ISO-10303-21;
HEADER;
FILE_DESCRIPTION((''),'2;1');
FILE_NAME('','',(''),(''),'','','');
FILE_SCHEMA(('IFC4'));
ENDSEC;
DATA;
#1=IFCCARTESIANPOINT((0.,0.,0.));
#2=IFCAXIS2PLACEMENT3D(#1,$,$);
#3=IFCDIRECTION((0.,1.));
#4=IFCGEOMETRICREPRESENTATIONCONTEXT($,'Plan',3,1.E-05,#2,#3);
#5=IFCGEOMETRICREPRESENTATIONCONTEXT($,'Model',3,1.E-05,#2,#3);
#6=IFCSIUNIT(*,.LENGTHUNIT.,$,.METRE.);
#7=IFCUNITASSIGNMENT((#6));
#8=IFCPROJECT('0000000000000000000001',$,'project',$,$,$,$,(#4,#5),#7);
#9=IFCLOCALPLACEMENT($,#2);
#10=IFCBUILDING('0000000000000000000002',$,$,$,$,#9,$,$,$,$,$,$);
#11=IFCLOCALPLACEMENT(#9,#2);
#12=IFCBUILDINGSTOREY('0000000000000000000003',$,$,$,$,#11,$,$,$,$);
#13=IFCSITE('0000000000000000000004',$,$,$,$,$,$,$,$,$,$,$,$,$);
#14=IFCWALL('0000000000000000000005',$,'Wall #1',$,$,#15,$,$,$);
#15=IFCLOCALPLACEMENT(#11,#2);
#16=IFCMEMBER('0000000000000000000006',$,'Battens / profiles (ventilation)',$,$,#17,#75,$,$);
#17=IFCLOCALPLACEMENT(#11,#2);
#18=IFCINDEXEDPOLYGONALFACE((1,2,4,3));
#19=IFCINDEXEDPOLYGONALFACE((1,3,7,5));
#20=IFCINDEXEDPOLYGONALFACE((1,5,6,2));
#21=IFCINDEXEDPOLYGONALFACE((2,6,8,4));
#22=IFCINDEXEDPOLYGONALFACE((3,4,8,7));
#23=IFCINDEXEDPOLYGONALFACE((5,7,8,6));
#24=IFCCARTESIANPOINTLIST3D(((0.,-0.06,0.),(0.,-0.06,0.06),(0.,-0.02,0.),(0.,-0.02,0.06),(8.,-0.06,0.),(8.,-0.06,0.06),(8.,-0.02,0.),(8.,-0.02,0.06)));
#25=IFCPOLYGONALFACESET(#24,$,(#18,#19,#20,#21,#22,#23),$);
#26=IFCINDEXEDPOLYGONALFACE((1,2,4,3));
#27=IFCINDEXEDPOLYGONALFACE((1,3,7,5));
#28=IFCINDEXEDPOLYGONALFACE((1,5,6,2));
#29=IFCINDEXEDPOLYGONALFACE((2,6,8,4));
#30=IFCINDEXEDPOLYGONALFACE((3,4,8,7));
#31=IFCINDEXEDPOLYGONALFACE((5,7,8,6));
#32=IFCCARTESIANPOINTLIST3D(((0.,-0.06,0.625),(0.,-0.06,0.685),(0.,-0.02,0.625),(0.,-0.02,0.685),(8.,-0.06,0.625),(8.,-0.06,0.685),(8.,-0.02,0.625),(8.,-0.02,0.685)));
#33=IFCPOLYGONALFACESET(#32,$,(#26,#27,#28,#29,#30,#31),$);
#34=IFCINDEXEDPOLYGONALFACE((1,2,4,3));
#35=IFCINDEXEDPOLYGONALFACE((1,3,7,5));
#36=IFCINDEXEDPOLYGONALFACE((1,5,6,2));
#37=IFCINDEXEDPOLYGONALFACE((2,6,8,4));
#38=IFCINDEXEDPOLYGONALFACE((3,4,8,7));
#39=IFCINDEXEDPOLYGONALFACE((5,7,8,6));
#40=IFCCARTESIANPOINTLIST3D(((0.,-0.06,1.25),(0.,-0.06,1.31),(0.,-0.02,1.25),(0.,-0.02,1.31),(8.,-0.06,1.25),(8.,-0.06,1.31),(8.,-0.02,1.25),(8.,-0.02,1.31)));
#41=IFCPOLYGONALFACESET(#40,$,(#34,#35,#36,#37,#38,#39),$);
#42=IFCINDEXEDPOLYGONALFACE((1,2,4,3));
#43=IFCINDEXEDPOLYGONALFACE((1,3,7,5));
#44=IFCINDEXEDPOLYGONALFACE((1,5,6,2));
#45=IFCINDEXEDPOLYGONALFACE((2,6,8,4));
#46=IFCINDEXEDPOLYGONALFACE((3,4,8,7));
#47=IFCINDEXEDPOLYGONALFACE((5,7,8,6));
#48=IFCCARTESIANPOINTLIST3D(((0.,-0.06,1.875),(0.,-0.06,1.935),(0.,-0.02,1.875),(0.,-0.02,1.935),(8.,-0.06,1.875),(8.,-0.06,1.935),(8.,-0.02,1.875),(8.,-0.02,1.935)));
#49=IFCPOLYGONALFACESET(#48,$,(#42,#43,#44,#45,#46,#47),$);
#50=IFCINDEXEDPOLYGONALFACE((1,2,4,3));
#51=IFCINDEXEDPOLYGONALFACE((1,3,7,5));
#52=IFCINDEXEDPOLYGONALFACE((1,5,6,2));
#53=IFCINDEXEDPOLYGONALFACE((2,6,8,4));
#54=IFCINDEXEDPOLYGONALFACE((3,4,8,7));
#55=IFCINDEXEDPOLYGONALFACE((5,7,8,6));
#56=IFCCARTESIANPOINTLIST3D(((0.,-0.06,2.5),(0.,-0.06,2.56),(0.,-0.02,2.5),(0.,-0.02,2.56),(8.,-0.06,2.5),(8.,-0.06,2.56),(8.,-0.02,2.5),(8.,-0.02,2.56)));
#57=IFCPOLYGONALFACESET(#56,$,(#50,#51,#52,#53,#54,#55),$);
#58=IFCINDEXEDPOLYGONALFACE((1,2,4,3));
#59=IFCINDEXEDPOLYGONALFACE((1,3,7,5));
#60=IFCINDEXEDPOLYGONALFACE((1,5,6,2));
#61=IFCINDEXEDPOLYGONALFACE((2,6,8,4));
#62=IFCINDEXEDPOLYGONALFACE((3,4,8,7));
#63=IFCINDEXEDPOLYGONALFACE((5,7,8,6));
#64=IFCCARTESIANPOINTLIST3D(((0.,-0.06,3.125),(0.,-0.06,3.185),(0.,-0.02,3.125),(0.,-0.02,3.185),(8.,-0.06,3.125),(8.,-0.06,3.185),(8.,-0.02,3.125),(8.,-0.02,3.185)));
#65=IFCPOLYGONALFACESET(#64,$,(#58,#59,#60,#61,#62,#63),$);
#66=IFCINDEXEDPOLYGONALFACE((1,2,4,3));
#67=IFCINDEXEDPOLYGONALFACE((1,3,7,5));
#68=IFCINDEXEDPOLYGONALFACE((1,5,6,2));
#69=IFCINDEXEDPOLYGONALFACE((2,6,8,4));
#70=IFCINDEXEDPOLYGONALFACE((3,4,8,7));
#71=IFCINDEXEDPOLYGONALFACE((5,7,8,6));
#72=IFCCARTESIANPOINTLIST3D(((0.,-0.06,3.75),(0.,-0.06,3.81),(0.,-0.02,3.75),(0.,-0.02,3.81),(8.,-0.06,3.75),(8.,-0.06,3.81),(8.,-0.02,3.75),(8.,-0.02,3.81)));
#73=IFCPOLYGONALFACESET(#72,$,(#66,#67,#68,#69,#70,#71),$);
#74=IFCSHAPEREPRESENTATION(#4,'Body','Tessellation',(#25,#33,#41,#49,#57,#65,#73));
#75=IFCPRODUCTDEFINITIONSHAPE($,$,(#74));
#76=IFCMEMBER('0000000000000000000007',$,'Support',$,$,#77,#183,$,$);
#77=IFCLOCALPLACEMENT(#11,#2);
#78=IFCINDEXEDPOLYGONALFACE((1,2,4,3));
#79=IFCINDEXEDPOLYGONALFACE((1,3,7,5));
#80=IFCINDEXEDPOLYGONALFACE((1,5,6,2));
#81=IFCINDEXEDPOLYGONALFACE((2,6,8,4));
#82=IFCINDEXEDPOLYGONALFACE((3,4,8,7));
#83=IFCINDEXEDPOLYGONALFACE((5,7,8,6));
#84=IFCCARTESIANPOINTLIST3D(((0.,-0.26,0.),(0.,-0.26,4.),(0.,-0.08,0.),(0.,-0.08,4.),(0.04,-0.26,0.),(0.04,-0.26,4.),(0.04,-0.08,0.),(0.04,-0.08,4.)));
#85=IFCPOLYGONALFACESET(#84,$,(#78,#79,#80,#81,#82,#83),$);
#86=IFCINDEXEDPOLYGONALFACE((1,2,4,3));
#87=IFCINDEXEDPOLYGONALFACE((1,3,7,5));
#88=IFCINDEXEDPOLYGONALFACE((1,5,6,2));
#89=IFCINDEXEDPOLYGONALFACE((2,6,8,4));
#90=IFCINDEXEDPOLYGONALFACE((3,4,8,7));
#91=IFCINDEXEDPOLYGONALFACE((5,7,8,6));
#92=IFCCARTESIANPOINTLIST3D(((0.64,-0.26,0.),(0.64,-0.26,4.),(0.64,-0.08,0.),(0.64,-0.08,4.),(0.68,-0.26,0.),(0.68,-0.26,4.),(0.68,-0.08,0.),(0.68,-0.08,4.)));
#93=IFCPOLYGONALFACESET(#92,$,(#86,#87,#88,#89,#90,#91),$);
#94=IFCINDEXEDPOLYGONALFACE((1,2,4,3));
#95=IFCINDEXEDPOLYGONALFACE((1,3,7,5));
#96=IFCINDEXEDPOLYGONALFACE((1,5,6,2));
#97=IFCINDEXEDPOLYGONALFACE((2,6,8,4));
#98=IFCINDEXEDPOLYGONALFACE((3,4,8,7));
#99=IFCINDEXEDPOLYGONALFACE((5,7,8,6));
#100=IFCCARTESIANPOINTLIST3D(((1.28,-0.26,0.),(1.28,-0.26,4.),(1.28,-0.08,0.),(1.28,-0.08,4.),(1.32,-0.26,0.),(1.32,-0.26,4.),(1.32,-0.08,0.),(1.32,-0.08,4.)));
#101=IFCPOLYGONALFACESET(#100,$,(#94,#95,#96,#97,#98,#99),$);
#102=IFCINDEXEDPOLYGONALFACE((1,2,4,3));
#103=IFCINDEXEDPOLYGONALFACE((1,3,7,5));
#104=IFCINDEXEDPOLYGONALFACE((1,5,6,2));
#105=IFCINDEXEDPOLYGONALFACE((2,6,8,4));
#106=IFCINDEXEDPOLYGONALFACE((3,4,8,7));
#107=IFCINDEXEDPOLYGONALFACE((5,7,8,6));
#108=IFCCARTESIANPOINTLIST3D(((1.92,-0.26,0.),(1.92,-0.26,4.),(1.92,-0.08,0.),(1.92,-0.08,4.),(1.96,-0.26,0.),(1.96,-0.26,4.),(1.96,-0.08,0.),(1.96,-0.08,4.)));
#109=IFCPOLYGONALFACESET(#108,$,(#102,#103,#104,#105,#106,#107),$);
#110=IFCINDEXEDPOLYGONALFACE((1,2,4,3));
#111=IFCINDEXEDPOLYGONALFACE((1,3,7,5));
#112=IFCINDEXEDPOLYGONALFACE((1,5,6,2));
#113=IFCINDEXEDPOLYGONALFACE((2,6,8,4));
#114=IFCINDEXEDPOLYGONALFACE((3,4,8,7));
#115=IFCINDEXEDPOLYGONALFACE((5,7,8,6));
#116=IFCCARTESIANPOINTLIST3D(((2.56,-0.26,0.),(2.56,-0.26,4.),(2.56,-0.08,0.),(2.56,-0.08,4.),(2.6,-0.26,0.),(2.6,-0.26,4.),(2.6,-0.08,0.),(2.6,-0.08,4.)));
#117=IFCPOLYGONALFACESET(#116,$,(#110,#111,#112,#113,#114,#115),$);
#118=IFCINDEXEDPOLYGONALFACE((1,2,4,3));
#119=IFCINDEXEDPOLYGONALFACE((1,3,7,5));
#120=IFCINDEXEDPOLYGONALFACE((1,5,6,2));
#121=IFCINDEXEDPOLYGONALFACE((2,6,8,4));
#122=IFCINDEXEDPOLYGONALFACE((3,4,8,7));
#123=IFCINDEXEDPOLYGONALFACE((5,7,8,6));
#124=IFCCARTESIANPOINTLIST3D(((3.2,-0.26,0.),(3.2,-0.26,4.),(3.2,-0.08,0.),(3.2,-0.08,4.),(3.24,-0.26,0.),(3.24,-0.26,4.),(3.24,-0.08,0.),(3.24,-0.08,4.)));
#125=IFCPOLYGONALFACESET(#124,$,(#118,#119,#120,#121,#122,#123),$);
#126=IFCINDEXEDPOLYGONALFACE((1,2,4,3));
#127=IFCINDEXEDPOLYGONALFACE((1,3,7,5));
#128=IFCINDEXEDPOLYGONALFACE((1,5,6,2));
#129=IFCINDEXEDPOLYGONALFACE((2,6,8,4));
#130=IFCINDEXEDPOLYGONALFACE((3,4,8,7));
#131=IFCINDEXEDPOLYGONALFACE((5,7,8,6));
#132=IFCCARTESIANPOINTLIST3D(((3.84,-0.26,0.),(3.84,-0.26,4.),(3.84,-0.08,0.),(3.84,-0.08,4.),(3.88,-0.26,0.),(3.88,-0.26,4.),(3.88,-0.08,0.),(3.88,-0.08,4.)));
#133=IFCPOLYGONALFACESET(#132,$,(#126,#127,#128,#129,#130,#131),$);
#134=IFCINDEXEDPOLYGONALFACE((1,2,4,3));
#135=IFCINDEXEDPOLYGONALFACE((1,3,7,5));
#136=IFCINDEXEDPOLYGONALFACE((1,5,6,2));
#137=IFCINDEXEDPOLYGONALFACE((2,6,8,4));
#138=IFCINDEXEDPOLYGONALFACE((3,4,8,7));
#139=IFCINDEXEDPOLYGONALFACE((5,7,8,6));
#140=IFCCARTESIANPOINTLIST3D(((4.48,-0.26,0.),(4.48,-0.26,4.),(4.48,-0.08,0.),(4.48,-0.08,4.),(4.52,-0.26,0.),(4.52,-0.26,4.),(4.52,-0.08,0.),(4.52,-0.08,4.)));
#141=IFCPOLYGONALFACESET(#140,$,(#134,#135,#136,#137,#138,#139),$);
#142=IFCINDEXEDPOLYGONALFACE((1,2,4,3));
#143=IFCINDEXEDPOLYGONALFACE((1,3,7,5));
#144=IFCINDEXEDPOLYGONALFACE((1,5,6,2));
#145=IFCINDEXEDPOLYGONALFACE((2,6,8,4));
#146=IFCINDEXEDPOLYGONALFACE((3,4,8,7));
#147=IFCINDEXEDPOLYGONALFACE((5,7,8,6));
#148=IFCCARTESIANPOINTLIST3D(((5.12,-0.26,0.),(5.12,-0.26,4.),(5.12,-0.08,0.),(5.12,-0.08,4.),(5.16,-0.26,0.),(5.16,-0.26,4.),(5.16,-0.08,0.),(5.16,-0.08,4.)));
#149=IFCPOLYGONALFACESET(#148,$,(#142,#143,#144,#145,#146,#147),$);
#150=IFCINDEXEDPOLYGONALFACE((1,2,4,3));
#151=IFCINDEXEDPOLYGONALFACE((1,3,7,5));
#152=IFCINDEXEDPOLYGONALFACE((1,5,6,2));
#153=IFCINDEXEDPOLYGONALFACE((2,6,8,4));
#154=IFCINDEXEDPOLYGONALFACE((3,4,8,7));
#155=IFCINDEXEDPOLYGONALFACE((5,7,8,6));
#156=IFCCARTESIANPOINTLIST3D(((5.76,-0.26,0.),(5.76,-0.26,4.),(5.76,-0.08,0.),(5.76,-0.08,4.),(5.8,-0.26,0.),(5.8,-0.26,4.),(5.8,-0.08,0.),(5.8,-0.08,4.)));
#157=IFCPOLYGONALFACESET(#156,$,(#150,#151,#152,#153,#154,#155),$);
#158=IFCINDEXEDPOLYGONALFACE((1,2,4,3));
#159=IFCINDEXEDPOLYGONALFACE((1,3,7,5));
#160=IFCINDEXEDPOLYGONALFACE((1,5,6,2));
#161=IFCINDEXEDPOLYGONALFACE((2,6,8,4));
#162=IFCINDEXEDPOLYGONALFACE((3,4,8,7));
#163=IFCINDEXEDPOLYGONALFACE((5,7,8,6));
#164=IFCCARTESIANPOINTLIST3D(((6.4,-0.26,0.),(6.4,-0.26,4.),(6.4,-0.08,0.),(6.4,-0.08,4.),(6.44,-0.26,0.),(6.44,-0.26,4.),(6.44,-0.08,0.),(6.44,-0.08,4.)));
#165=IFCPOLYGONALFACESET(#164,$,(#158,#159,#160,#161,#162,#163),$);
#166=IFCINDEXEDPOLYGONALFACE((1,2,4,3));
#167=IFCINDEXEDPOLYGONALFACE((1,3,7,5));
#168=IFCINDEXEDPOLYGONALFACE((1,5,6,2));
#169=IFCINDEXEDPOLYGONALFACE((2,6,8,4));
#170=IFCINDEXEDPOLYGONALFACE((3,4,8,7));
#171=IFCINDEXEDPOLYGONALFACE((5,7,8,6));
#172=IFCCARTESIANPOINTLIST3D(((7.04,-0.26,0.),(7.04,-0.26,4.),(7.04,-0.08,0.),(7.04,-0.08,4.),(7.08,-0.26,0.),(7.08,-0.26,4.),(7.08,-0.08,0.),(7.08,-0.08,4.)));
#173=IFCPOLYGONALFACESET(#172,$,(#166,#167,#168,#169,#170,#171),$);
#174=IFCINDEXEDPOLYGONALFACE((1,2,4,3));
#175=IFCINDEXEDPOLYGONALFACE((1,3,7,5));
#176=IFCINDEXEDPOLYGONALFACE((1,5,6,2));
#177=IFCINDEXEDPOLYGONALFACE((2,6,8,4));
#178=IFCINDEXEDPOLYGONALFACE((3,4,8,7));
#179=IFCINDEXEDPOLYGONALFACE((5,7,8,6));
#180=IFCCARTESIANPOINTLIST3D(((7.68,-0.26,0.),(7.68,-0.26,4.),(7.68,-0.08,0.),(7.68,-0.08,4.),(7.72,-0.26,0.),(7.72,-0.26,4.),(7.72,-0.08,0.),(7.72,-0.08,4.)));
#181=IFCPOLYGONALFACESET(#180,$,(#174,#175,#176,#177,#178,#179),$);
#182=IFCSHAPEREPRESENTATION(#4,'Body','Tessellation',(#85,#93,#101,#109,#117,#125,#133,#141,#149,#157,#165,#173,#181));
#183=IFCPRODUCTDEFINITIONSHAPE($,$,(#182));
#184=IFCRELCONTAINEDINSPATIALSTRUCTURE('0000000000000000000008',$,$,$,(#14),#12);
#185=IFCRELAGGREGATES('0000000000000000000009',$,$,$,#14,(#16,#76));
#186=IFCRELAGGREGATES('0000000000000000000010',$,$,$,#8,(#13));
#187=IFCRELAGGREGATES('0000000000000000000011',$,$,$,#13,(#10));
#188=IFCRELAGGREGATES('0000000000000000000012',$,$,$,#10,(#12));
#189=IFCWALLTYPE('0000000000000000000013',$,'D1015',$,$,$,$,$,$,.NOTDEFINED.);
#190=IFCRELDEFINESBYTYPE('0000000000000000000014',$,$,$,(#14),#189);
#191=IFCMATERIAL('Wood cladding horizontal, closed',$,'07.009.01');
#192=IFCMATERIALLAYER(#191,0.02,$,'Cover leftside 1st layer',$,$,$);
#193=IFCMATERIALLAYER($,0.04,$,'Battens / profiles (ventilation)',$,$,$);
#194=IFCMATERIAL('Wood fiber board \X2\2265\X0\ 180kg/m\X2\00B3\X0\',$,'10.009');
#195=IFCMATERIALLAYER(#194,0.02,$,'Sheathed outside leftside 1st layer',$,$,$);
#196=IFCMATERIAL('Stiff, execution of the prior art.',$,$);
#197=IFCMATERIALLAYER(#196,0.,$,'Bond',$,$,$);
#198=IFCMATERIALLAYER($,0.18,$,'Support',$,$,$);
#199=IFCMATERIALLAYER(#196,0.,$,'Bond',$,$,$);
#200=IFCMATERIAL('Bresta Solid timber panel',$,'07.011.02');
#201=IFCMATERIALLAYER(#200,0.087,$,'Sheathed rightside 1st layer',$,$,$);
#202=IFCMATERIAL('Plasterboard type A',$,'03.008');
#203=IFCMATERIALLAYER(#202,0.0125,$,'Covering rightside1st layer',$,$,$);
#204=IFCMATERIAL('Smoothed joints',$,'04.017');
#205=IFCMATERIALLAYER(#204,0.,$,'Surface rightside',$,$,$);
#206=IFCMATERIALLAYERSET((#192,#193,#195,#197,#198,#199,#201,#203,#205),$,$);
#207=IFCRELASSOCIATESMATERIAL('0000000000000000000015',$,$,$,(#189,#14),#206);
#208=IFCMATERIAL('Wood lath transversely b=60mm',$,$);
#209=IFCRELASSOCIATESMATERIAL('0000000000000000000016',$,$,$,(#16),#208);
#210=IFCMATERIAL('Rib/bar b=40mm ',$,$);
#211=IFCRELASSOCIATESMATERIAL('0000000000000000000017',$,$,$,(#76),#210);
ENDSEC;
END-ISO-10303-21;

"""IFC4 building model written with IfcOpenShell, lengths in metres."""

from ifc_helpers import new_model, si_unit, direction, frame, frame_2d, origin, place, context, project, spatial, rectangle, extrude, material, layer, layer_set, type_object, element, aggregate, save


model = new_model("IFC4")

# Units and contexts
plan_context = context("Plan", 3, precision=1e-05, world=origin(), true_north=direction((0.0, 1.0)))
model_context = context("Model", 3, precision=1e-05, world=origin(), true_north=direction((0.0, 1.0)))
ifc_project = project(units=[si_unit("LENGTHUNIT", "METRE")], contexts=[plan_context, model_context])

# Site, building, storey
site = spatial("IfcSite", under=ifc_project)
building_placement = place(None, origin())
building = spatial("IfcBuilding", under=site, at=building_placement)
storey_placement = place(building_placement, origin())
storey = spatial("IfcBuildingStorey", under=building, at=storey_placement)

# Wall, members
ifc_material_1 = material(Name="Wood cladding horizontal, closed", Category="07.009.01")
ifc_layer_1 = layer(ifc_material_1, 0.02, Name="Cover leftside 1st layer")
ifc_layer_2 = layer(None, 0.04, Name="Battens / profiles (ventilation)")
ifc_material_2 = material(Name="Wood fiber board ≥ 180kg/m³", Category="10.009")
ifc_layer_3 = layer(ifc_material_2, 0.02, Name="Sheathed outside leftside 1st layer")
ifc_material_3 = material(Name="Stiff, execution of the prior art.")
ifc_layer_4 = layer(ifc_material_3, 0.0, Name="Bond")
ifc_layer_5 = layer(None, 0.18, Name="Support")
ifc_layer_6 = layer(ifc_material_3, 0.0, Name="Bond")
ifc_material_4 = material(Name="Bresta Solid timber panel", Category="07.011.02")
ifc_layer_7 = layer(ifc_material_4, 0.087, Name="Sheathed rightside 1st layer")
ifc_material_5 = material(Name="Plasterboard type A", Category="03.008")
ifc_layer_8 = layer(ifc_material_5, 0.0125, Name="Covering rightside1st layer")
ifc_material_6 = material(Name="Smoothed joints", Category="04.017")
ifc_layer_9 = layer(ifc_material_6, 0.0, Name="Surface rightside")
ifc_layer_set = layer_set([ifc_layer_1, ifc_layer_2, ifc_layer_3, ifc_layer_4, ifc_layer_5, ifc_layer_6, ifc_layer_7, ifc_layer_8, ifc_layer_9])
wall_type = type_object("IfcWallType", Name="D1015", PredefinedType="NOTDEFINED", material=ifc_layer_set)
wall_placement = place(None, frame((0.0, 0.0, 0.0), z_axis=(0.0, -1.0, 0.0), x_axis=(1.0, 0.0, 0.0)))
wall = element("IfcWall", 1, at=wall_placement, inside=storey, type_object=wall_type, material=ifc_layer_set, Name="Wall #1")
ifc_material_7 = material(Name="Wood lath transversely b=60mm")
member_1_placement = place(wall_placement, origin())
member_1 = element("IfcMember", 2, at=member_1_placement, material=ifc_material_7, Name="Battens / profiles (ventilation)", context=plan_context, shape_type="SweptSolid", body=[
    extrude(rectangle(XDim=0.06, YDim=0.04, at=frame_2d((0.03, 0.02), x_axis=(1.0, 0.0))), frame((0.0, 0.0, 0.02), z_axis=(1.0, 0.0, 0.0), x_axis=(0.0, 1.0, 0.0)), (0.0, 0.0, 1.0), 8.0),
    extrude(rectangle(XDim=0.06, YDim=0.04, at=frame_2d((0.03, 0.02), x_axis=(1.0, 0.0))), frame((0.0, 0.625, 0.02), z_axis=(1.0, 0.0, 0.0), x_axis=(0.0, 1.0, 0.0)), (0.0, 0.0, 1.0), 8.0),
    extrude(rectangle(XDim=0.06, YDim=0.04, at=frame_2d((0.03, 0.02), x_axis=(1.0, 0.0))), frame((0.0, 1.25, 0.02), z_axis=(1.0, 0.0, 0.0), x_axis=(0.0, 1.0, 0.0)), (0.0, 0.0, 1.0), 8.0),
    extrude(rectangle(XDim=0.06, YDim=0.04, at=frame_2d((0.03, 0.02), x_axis=(1.0, 0.0))), frame((0.0, 1.875, 0.02), z_axis=(1.0, 0.0, 0.0), x_axis=(0.0, 1.0, 0.0)), (0.0, 0.0, 1.0), 8.0),
    extrude(rectangle(XDim=0.06, YDim=0.04, at=frame_2d((0.03, 0.02), x_axis=(1.0, 0.0))), frame((0.0, 2.5, 0.02), z_axis=(1.0, 0.0, 0.0), x_axis=(0.0, 1.0, 0.0)), (0.0, 0.0, 1.0), 8.0),
    extrude(rectangle(XDim=0.06, YDim=0.04, at=frame_2d((0.03, 0.02), x_axis=(1.0, 0.0))), frame((0.0, 3.125, 0.02), z_axis=(1.0, 0.0, 0.0), x_axis=(0.0, 1.0, 0.0)), (0.0, 0.0, 1.0), 8.0),
    extrude(rectangle(XDim=0.06, YDim=0.04, at=frame_2d((0.03, 0.02), x_axis=(1.0, 0.0))), frame((0.0, 3.75, 0.02), z_axis=(1.0, 0.0, 0.0), x_axis=(0.0, 1.0, 0.0)), (0.0, 0.0, 1.0), 8.0),
])
ifc_material_8 = material(Name="Rib/bar b=40mm ")
member_2_placement = place(wall_placement, origin())
member_2 = element("IfcMember", 3, at=member_2_placement, material=ifc_material_8, Name="Support", context=plan_context, shape_type="SweptSolid", body=[
    extrude(rectangle(XDim=0.04, YDim=0.18, at=frame_2d((0.02, 0.09), x_axis=(1.0, 0.0))), frame((0.0, 4.0, 0.08), z_axis=(0.0, -1.0, 0.0), x_axis=(1.0, 0.0, 0.0)), (0.0, 0.0, 1.0), 4.0),
    extrude(rectangle(XDim=0.04, YDim=0.18, at=frame_2d((0.02, 0.09), x_axis=(1.0, 0.0))), frame((0.64, 4.0, 0.08), z_axis=(0.0, -1.0, 0.0), x_axis=(1.0, 0.0, 0.0)), (0.0, 0.0, 1.0), 4.0),
    extrude(rectangle(XDim=0.04, YDim=0.18, at=frame_2d((0.02, 0.09), x_axis=(1.0, 0.0))), frame((1.28, 4.0, 0.08), z_axis=(0.0, -1.0, 0.0), x_axis=(1.0, 0.0, 0.0)), (0.0, 0.0, 1.0), 4.0),
    extrude(rectangle(XDim=0.04, YDim=0.18, at=frame_2d((0.02, 0.09), x_axis=(1.0, 0.0))), frame((1.92, 4.0, 0.08), z_axis=(0.0, -1.0, 0.0), x_axis=(1.0, 0.0, 0.0)), (0.0, 0.0, 1.0), 4.0),
    extrude(rectangle(XDim=0.04, YDim=0.18, at=frame_2d((0.02, 0.09), x_axis=(1.0, 0.0))), frame((2.56, 4.0, 0.08), z_axis=(0.0, -1.0, 0.0), x_axis=(1.0, 0.0, 0.0)), (0.0, 0.0, 1.0), 4.0),
    extrude(rectangle(XDim=0.04, YDim=0.18, at=frame_2d((0.02, 0.09), x_axis=(1.0, 0.0))), frame((3.2, 4.0, 0.08), z_axis=(0.0, -1.0, 0.0), x_axis=(1.0, 0.0, 0.0)), (0.0, 0.0, 1.0), 4.0),
    extrude(rectangle(XDim=0.04, YDim=0.18, at=frame_2d((0.02, 0.09), x_axis=(1.0, 0.0))), frame((3.84, 4.0, 0.08), z_axis=(0.0, -1.0, 0.0), x_axis=(1.0, 0.0, 0.0)), (0.0, 0.0, 1.0), 4.0),
    extrude(rectangle(XDim=0.04, YDim=0.18, at=frame_2d((0.02, 0.09), x_axis=(1.0, 0.0))), frame((4.48, 4.0, 0.08), z_axis=(0.0, -1.0, 0.0), x_axis=(1.0, 0.0, 0.0)), (0.0, 0.0, 1.0), 4.0),
    extrude(rectangle(XDim=0.04, YDim=0.18, at=frame_2d((0.02, 0.09), x_axis=(1.0, 0.0))), frame((5.12, 4.0, 0.08), z_axis=(0.0, -1.0, 0.0), x_axis=(1.0, 0.0, 0.0)), (0.0, 0.0, 1.0), 4.0),
    extrude(rectangle(XDim=0.04, YDim=0.18, at=frame_2d((0.02, 0.09), x_axis=(1.0, 0.0))), frame((5.76, 4.0, 0.08), z_axis=(0.0, -1.0, 0.0), x_axis=(1.0, 0.0, 0.0)), (0.0, 0.0, 1.0), 4.0),
    extrude(rectangle(XDim=0.04, YDim=0.18, at=frame_2d((0.02, 0.09), x_axis=(1.0, 0.0))), frame((6.4, 4.0, 0.08), z_axis=(0.0, -1.0, 0.0), x_axis=(1.0, 0.0, 0.0)), (0.0, 0.0, 1.0), 4.0),
    extrude(rectangle(XDim=0.04, YDim=0.18, at=frame_2d((0.02, 0.09), x_axis=(1.0, 0.0))), frame((7.04, 4.0, 0.08), z_axis=(0.0, -1.0, 0.0), x_axis=(1.0, 0.0, 0.0)), (0.0, 0.0, 1.0), 4.0),
    extrude(rectangle(XDim=0.04, YDim=0.18, at=frame_2d((0.02, 0.09), x_axis=(1.0, 0.0))), frame((7.68, 4.0, 0.08), z_axis=(0.0, -1.0, 0.0), x_axis=(1.0, 0.0, 0.0)), (0.0, 0.0, 1.0), 4.0),
])
aggregate(wall, [member_1, member_2])

save(model, "model.ifc")
